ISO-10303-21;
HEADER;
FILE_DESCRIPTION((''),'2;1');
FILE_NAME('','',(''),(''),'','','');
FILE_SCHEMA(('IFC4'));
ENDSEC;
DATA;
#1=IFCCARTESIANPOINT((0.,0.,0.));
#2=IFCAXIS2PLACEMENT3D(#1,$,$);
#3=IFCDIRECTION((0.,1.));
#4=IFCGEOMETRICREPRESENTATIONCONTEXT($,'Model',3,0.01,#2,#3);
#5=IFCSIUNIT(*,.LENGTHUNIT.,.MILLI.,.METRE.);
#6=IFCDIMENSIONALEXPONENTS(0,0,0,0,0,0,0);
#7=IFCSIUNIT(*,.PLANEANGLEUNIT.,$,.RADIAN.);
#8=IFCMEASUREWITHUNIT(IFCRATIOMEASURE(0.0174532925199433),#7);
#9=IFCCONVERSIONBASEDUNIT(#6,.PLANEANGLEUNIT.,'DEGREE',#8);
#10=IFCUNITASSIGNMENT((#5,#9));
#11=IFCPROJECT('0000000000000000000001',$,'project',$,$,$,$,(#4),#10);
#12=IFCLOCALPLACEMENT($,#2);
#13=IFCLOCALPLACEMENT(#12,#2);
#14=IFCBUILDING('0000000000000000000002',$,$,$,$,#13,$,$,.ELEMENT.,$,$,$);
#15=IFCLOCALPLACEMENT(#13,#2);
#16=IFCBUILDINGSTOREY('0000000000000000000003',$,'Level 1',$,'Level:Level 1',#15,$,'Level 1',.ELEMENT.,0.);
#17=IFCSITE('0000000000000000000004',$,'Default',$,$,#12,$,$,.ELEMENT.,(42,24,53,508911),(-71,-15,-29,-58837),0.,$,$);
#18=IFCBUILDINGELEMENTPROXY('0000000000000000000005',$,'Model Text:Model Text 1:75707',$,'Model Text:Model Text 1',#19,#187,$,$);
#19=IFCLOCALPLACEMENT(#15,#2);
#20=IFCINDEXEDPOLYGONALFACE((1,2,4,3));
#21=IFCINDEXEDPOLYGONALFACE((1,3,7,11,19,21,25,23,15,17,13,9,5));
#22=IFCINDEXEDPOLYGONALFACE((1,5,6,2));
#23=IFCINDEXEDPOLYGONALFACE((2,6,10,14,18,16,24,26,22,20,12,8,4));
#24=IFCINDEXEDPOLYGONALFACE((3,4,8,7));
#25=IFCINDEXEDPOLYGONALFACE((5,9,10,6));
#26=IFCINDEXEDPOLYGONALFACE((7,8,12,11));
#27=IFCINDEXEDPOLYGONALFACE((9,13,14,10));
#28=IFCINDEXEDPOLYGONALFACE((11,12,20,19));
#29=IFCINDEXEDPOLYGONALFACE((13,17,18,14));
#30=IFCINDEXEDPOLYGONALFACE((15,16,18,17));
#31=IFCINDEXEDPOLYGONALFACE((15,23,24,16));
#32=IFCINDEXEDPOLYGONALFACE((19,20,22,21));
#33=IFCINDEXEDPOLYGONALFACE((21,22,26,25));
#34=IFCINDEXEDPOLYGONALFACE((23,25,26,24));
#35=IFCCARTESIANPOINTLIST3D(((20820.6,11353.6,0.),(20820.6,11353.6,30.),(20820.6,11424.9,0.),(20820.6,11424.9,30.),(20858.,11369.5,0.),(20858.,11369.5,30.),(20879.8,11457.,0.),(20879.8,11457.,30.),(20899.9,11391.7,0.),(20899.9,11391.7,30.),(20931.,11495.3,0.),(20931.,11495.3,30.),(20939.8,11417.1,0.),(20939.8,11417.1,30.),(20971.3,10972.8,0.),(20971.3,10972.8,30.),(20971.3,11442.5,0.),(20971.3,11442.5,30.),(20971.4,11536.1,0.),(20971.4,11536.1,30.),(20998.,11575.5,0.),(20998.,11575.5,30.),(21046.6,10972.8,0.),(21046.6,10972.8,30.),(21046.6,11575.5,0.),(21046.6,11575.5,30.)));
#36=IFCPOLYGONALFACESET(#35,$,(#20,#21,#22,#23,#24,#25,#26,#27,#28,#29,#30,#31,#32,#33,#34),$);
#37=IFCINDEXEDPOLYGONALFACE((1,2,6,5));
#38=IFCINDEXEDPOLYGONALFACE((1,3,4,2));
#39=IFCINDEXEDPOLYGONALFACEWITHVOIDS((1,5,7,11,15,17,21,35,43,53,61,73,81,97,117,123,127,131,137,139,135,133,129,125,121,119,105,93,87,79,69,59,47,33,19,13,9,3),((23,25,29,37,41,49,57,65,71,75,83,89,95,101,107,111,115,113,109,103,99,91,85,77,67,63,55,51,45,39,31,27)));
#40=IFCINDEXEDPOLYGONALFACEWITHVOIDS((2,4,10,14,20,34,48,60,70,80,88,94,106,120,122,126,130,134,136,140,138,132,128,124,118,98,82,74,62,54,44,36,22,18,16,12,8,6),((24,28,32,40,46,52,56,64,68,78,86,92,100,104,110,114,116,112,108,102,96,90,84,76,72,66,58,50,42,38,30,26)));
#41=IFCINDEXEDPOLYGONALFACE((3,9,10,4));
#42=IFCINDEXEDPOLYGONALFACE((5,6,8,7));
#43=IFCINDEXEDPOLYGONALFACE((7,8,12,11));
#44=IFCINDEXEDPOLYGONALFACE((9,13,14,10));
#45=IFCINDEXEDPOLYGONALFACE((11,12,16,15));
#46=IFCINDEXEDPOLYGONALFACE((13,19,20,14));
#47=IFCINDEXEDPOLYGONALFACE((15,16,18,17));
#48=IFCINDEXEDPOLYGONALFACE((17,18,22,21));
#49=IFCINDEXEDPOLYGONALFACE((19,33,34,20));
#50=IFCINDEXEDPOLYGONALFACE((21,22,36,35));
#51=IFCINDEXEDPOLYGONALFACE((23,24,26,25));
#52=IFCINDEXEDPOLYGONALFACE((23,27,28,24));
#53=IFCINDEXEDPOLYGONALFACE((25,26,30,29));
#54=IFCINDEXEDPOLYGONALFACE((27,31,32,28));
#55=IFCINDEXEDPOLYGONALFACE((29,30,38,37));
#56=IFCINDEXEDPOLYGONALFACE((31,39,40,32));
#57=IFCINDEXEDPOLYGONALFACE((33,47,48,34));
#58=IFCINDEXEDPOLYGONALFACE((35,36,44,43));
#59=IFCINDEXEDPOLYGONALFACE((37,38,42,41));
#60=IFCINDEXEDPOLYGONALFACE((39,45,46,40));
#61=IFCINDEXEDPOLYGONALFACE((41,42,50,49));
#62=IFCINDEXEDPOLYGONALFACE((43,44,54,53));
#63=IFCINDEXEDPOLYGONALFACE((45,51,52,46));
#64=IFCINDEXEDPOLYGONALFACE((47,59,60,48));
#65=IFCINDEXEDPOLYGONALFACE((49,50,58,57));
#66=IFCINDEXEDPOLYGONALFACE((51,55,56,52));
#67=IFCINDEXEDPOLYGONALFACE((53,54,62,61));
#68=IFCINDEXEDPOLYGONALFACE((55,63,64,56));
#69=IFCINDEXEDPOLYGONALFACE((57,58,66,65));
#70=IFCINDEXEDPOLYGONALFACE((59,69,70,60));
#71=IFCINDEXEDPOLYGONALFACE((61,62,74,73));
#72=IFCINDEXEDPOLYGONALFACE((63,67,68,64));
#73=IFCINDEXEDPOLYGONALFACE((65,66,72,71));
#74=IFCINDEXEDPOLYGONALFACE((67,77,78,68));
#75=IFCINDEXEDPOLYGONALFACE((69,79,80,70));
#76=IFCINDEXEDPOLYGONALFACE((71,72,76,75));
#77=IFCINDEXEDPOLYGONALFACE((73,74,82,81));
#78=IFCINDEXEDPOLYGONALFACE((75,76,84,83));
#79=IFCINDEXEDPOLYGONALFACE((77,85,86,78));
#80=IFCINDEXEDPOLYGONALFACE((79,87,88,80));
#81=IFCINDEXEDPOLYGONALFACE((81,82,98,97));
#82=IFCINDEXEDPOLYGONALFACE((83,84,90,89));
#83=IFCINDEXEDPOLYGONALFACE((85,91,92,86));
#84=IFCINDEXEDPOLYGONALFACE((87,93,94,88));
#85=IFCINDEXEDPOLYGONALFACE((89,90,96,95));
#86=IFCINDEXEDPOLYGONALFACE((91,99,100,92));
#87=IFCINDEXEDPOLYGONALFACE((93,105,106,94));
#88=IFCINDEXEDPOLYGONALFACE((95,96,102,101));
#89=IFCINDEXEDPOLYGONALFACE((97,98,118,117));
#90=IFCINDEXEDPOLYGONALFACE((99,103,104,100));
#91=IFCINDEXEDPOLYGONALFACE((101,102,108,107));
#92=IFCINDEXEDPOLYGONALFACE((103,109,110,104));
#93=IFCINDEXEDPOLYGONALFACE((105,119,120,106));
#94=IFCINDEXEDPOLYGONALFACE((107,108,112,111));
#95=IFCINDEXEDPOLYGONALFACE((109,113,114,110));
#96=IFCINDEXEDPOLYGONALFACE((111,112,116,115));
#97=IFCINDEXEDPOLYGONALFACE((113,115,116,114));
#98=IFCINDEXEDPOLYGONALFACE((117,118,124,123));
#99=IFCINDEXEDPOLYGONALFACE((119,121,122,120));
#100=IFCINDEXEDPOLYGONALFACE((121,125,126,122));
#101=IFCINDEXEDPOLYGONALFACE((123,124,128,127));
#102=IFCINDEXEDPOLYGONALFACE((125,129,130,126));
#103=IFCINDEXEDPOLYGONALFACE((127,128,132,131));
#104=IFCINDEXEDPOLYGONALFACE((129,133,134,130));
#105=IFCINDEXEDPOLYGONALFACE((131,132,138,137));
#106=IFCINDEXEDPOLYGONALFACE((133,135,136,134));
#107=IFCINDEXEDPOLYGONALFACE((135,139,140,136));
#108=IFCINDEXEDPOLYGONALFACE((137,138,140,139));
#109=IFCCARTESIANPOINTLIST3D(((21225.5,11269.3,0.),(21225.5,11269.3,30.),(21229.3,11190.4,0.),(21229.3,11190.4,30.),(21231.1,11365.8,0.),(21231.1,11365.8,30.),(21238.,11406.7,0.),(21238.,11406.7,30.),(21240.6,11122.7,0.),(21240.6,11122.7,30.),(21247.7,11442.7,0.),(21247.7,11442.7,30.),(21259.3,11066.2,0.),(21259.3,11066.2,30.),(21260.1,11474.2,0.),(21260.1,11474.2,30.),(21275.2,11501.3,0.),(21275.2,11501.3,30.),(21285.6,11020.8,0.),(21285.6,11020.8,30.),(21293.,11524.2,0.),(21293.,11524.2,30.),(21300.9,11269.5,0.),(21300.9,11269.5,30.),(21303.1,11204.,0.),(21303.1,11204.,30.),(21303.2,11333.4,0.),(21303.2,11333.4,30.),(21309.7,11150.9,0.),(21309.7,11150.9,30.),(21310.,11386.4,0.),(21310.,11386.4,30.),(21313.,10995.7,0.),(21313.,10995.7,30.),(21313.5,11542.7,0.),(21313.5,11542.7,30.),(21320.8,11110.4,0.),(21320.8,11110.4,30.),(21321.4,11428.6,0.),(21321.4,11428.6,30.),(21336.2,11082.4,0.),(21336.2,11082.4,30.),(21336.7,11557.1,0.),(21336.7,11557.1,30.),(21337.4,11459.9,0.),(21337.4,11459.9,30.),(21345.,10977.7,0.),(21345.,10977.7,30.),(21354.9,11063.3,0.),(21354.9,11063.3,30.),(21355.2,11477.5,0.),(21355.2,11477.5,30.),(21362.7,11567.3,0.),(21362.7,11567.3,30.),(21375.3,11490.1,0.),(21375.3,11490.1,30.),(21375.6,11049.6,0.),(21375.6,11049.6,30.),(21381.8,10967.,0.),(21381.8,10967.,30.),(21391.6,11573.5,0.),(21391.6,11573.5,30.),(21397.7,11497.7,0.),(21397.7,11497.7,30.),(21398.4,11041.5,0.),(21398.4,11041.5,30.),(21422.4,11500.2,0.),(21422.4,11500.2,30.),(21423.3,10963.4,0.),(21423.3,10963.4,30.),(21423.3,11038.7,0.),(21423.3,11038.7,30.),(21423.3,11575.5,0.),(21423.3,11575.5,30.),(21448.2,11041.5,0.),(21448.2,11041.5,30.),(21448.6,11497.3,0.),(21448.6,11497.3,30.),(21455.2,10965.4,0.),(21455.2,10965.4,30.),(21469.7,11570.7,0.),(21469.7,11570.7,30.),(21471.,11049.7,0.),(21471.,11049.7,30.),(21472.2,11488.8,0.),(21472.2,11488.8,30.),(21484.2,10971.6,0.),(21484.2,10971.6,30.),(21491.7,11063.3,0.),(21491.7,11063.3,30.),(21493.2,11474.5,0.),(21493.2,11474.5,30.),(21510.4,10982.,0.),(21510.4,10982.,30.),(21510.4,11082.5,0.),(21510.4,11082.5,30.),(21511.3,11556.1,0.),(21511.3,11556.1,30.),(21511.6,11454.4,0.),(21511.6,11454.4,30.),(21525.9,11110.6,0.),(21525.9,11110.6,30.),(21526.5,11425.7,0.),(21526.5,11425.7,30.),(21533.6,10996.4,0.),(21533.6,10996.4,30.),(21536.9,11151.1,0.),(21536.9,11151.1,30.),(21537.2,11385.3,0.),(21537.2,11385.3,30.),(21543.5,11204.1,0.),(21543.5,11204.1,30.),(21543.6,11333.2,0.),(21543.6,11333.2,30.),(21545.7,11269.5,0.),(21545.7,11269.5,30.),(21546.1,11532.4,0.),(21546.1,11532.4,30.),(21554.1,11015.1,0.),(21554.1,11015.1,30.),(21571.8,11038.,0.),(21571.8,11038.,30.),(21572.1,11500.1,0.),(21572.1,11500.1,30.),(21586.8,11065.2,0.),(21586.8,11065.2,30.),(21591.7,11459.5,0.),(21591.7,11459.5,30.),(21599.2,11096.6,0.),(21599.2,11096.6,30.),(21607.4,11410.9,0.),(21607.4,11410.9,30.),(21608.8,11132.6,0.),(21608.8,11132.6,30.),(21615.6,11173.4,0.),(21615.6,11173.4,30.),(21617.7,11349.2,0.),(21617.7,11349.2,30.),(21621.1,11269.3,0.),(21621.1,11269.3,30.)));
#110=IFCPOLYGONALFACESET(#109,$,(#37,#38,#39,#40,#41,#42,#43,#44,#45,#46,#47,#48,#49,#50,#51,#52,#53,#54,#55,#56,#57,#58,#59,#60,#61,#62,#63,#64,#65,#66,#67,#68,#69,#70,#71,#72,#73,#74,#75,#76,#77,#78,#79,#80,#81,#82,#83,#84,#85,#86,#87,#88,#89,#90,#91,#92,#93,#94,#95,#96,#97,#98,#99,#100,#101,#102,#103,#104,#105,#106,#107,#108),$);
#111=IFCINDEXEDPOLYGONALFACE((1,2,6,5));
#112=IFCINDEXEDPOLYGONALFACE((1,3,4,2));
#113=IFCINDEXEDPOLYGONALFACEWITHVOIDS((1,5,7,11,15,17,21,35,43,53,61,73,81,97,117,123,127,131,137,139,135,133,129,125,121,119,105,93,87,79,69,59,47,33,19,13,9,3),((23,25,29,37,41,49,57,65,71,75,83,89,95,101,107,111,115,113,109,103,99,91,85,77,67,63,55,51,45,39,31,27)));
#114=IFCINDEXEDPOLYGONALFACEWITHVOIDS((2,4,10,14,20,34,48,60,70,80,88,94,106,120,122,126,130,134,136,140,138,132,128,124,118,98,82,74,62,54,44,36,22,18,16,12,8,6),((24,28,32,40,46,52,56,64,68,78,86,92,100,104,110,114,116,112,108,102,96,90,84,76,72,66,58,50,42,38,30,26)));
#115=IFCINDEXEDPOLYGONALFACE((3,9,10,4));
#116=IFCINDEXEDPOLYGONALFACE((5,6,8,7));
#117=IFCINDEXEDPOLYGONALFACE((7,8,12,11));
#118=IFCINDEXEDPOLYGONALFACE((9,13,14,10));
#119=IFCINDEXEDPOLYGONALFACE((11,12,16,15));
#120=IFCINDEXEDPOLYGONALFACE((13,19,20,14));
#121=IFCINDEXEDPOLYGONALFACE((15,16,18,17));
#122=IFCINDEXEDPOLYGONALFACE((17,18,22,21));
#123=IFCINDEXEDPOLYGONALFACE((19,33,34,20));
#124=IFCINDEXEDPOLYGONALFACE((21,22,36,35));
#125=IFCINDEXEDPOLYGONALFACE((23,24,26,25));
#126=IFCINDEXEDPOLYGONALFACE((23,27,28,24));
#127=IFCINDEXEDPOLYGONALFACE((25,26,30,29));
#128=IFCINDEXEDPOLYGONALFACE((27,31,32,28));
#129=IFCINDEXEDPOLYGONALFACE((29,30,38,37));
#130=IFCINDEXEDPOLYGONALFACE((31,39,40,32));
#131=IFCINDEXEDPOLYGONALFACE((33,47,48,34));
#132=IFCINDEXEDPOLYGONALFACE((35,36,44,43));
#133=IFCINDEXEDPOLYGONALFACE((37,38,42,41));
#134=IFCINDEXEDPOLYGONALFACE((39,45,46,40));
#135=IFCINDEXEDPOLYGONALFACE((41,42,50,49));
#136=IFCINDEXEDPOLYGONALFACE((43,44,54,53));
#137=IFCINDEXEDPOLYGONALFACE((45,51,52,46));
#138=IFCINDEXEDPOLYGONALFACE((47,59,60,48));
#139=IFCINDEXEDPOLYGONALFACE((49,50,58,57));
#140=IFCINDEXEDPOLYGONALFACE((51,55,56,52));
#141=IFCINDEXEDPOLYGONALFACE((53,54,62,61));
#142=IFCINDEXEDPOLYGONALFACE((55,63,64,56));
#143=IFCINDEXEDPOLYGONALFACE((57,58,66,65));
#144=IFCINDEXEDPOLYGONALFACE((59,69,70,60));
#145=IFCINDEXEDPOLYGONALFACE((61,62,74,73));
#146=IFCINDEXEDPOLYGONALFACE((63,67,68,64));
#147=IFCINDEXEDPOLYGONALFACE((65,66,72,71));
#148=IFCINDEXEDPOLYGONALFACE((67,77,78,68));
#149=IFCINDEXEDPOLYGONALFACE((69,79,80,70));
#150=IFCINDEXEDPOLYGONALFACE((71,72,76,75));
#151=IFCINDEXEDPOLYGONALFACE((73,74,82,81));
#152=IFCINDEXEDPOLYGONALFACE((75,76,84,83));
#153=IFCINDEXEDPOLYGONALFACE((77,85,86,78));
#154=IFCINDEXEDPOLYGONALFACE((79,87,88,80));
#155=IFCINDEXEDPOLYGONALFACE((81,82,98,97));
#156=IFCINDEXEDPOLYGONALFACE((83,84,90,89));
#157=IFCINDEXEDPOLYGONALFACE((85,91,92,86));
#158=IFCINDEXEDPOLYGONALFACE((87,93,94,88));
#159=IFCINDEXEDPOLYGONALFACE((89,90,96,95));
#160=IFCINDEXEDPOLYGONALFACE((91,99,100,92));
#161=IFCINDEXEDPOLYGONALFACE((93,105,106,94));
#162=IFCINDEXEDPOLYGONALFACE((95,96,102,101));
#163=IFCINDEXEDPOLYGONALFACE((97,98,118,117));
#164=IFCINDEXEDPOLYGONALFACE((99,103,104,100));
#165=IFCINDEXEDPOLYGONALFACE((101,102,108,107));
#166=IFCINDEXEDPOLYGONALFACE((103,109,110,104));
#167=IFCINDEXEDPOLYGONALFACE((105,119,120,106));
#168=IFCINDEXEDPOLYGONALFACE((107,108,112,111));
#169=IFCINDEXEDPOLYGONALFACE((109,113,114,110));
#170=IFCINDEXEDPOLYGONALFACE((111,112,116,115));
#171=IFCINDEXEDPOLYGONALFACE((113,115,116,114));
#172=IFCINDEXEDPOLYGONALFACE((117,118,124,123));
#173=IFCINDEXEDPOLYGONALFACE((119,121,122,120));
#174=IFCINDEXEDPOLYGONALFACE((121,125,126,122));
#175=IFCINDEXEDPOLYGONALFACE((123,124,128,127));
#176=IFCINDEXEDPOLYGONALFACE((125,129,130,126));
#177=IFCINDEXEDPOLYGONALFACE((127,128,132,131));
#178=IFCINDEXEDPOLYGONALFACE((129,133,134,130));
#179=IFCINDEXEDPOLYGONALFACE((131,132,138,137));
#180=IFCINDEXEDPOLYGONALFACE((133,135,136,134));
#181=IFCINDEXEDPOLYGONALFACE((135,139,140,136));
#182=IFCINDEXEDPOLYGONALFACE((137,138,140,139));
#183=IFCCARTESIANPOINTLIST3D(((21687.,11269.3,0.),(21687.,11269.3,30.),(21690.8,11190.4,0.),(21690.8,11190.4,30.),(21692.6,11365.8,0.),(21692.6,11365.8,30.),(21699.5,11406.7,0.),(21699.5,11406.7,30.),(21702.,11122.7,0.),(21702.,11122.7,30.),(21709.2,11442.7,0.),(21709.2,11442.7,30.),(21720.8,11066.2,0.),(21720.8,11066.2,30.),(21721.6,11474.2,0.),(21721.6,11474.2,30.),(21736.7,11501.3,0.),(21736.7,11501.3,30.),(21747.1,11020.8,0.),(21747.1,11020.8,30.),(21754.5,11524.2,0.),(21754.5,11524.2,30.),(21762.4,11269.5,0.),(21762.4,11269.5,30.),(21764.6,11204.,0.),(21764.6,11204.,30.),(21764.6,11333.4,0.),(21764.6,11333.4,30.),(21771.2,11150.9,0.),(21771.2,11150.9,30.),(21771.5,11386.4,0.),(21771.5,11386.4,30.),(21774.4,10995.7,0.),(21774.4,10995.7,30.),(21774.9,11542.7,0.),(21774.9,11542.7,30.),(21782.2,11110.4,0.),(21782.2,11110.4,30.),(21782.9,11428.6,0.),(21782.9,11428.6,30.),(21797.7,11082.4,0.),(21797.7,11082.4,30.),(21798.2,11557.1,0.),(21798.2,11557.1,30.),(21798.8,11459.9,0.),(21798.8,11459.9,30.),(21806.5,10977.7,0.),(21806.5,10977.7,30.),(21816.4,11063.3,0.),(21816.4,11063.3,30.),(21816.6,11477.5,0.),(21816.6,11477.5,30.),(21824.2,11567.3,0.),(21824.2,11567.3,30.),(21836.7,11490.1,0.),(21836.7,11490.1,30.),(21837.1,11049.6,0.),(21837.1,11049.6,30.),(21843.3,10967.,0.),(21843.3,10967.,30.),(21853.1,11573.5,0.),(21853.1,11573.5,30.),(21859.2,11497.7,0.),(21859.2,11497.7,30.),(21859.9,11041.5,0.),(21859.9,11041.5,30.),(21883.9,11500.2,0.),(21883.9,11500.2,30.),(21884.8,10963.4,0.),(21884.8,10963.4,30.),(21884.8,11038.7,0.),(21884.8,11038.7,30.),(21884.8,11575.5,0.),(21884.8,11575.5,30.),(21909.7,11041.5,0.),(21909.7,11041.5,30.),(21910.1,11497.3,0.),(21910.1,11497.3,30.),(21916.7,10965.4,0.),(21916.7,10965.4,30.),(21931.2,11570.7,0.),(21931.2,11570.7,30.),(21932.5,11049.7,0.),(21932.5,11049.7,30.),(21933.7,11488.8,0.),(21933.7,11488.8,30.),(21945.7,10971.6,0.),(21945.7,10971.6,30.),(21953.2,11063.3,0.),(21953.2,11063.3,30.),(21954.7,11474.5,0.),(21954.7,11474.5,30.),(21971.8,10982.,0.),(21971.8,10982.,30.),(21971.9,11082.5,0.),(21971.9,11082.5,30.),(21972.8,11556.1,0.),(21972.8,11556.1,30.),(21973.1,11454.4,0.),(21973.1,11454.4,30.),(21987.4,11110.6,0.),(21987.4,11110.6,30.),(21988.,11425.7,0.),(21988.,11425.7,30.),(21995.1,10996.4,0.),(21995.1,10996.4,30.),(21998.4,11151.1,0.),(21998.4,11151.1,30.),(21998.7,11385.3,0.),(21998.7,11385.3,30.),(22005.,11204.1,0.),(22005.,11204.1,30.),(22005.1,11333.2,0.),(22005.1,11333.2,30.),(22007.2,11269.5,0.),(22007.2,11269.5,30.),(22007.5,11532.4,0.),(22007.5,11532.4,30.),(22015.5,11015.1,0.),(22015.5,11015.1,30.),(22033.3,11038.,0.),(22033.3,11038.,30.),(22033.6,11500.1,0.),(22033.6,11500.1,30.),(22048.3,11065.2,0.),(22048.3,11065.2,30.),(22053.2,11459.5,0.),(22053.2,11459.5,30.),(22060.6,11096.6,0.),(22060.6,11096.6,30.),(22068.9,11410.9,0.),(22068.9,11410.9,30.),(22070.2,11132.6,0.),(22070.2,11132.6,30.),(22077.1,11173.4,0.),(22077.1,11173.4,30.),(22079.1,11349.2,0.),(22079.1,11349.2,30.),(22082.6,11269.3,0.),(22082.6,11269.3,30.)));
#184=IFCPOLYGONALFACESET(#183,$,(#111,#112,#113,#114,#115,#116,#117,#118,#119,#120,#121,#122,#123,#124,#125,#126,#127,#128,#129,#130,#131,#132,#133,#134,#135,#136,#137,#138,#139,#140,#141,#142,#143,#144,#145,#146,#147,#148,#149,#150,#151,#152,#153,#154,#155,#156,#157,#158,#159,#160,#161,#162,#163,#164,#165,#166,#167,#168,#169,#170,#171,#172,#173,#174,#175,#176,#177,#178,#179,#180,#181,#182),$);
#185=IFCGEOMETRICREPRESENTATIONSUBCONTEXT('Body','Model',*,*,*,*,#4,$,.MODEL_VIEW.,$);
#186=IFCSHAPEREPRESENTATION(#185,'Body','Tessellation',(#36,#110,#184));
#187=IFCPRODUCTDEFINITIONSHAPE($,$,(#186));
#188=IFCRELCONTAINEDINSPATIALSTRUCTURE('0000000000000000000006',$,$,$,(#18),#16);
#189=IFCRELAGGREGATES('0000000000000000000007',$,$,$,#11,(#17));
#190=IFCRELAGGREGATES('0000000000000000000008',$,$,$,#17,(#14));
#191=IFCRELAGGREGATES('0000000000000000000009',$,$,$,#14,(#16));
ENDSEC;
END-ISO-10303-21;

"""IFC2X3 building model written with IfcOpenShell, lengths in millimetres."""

from ifc_helpers import new_model, entity, si_unit, converted_unit, direction, frame, origin, place, context, subcontext, project, spatial, polyline, outline, extrude, element, save


model = new_model("IFC2X3")

# Units and contexts
model_context = context("Model", 3, precision=0.01, world=origin(), true_north=direction((0.0, 1.0)))
body_context = subcontext(model_context, "Body", "Model", "MODEL_VIEW")
ifc_project = project(units=[si_unit("LENGTHUNIT", "METRE", prefix="MILLI"), converted_unit("PLANEANGLEUNIT", "DEGREE", entity("IfcRatioMeasure", 0.0174532925199433), si_unit("PLANEANGLEUNIT", "RADIAN"), dimensions=[0, 0, 0, 0, 0, 0, 0])], contexts=[model_context])

# Site, building, storey
site_placement = place(None, origin())
site = spatial("IfcSite", under=ifc_project, at=site_placement, Name="Default", CompositionType="ELEMENT", RefLatitude=(42, 24, 53, 508911), RefLongitude=(-71, -15, -29, -58837), RefElevation=0.0)
building_placement = place(site_placement, origin())
building = spatial("IfcBuilding", under=site, at=building_placement, CompositionType="ELEMENT")
storey_placement = place(building_placement, origin())
storey = spatial("IfcBuildingStorey", under=building, at=storey_placement, Name="Level 1", ObjectType="Level:Level 1", LongName="Level 1", CompositionType="ELEMENT", Elevation=0.0)

# Building element proxy
proxy_1_placement = place(storey_placement, origin())
element("IfcBuildingElementProxy", 1, at=proxy_1_placement, inside=storey, Name="Model Text:Model Text 1:75707", ObjectType="Model Text:Model Text 1", context=body_context, shape_type="SweptSolid", body=[
    extrude(outline(polyline([(-410.6, -111.6), (192.1, -111.6), (192.1, -63.1), (152.7, -36.4), (111.9, 4.0), (73.6, 55.2), (41.4, 114.4), (-29.8, 114.4), (-13.9, 77.0), (8.3, 35.1), (33.7, -4.8), (59.1, -36.3), (-410.6, -36.3), (-410.6, -111.6)])), frame((20935.0, 11383.4, 0.0), z_axis=(0.0, 0.0, 1.0), x_axis=(0.0, 1.0, 0.0)), (0.0, 0.0, 1.0), 30.0),
    extrude(outline(polyline([(-10.6, -198.7), (68.3, -198.7), (136.5, -190.7), (193.9, -174.7), (240.5, -150.6), (266.9, -124.4), (286.3, -93.2), (298.8, -57.0), (304.3, -15.7), (303.8, 16.2), (299.0, 45.5), (289.9, 72.1), (276.6, 96.0), (258.9, 117.3), (236.9, 136.2), (210.4, 152.5), (179.6, 166.3), (144.1, 177.6), (103.7, 186.3), (8.2, 196.4), (-71.8, 196.7), (-134.0, 189.4), (-183.3, 176.1), (-224.7, 158.4), (-258.2, 133.9), (-283.5, 100.3), (-300.1, 59.5), (-307.1, 13.4), (-306.6, -18.4), (-301.8, -47.5), (-292.8, -74.0), (-279.6, -97.9), (-262.0, -119.2), (-240.0, -138.1), (-213.6, -154.5), (-182.8, -168.4), (-147.3, -179.8), (-106.7, -188.6), (-10.6, -198.7)]), holes=[polyline([(-7.2, -123.5), (-71.0, -118.2), (-123.6, -108.8), (-165.2, -95.4), (-195.7, -78.0), (-212.4, -59.4), (-224.1, -38.7), (-230.6, -15.9), (-231.9, 8.9), (-227.8, 35.0), (-218.1, 58.1), (-202.8, 78.4), (-182.0, 95.8), (-152.6, 109.4), (-111.7, 118.1), (-59.4, 122.0), (4.4, 121.1), (69.6, 115.8), (122.2, 106.7), (162.2, 93.7), (189.5, 77.0), (207.7, 57.4), (220.4, 36.0), (227.5, 12.8), (229.1, -12.1), (225.2, -36.8), (215.9, -59.2), (201.3, -79.3), (181.4, -97.1), (152.6, -111.2), (111.6, -120.3), (58.3, -124.4), (-7.2, -123.5)])]), frame((21424.6, 11268.1, 0.0), z_axis=(0.0, 0.0, 1.0), x_axis=(0.047515, -0.998871, 0.0)), (0.0, 0.0, 1.0), 30.0),
    extrude(outline(polyline([(-10.6, -198.7), (68.3, -198.7), (136.5, -190.7), (193.9, -174.7), (240.5, -150.6), (266.9, -124.4), (286.3, -93.2), (298.8, -57.0), (304.3, -15.7), (303.8, 16.2), (299.0, 45.5), (289.9, 72.1), (276.6, 96.0), (258.9, 117.3), (236.9, 136.2), (210.4, 152.5), (179.6, 166.3), (144.1, 177.6), (103.7, 186.3), (8.2, 196.4), (-71.8, 196.7), (-134.0, 189.4), (-183.3, 176.1), (-224.7, 158.4), (-258.2, 133.9), (-283.5, 100.3), (-300.1, 59.5), (-307.1, 13.4), (-306.6, -18.4), (-301.8, -47.5), (-292.8, -74.0), (-279.6, -97.9), (-262.0, -119.2), (-240.0, -138.1), (-213.6, -154.5), (-182.8, -168.4), (-147.3, -179.8), (-106.7, -188.6), (-10.6, -198.7)]), holes=[polyline([(-7.2, -123.5), (-71.0, -118.2), (-123.6, -108.8), (-165.2, -95.4), (-195.7, -78.0), (-212.4, -59.4), (-224.1, -38.7), (-230.6, -15.9), (-231.9, 8.9), (-227.8, 35.0), (-218.1, 58.1), (-202.8, 78.4), (-182.0, 95.8), (-152.6, 109.4), (-111.7, 118.1), (-59.4, 122.0), (4.4, 121.1), (69.6, 115.8), (122.2, 106.7), (162.2, 93.7), (189.5, 77.0), (207.7, 57.4), (220.4, 36.0), (227.5, 12.8), (229.1, -12.1), (225.2, -36.8), (215.9, -59.2), (201.3, -79.3), (181.4, -97.1), (152.6, -111.2), (111.6, -120.3), (58.3, -124.4), (-7.2, -123.5)])]), frame((21886.0, 11268.1, 0.0), z_axis=(0.0, 0.0, 1.0), x_axis=(0.047515, -0.998871, 0.0)), (0.0, 0.0, 1.0), 30.0),
])

save(model, "model.ifc")
